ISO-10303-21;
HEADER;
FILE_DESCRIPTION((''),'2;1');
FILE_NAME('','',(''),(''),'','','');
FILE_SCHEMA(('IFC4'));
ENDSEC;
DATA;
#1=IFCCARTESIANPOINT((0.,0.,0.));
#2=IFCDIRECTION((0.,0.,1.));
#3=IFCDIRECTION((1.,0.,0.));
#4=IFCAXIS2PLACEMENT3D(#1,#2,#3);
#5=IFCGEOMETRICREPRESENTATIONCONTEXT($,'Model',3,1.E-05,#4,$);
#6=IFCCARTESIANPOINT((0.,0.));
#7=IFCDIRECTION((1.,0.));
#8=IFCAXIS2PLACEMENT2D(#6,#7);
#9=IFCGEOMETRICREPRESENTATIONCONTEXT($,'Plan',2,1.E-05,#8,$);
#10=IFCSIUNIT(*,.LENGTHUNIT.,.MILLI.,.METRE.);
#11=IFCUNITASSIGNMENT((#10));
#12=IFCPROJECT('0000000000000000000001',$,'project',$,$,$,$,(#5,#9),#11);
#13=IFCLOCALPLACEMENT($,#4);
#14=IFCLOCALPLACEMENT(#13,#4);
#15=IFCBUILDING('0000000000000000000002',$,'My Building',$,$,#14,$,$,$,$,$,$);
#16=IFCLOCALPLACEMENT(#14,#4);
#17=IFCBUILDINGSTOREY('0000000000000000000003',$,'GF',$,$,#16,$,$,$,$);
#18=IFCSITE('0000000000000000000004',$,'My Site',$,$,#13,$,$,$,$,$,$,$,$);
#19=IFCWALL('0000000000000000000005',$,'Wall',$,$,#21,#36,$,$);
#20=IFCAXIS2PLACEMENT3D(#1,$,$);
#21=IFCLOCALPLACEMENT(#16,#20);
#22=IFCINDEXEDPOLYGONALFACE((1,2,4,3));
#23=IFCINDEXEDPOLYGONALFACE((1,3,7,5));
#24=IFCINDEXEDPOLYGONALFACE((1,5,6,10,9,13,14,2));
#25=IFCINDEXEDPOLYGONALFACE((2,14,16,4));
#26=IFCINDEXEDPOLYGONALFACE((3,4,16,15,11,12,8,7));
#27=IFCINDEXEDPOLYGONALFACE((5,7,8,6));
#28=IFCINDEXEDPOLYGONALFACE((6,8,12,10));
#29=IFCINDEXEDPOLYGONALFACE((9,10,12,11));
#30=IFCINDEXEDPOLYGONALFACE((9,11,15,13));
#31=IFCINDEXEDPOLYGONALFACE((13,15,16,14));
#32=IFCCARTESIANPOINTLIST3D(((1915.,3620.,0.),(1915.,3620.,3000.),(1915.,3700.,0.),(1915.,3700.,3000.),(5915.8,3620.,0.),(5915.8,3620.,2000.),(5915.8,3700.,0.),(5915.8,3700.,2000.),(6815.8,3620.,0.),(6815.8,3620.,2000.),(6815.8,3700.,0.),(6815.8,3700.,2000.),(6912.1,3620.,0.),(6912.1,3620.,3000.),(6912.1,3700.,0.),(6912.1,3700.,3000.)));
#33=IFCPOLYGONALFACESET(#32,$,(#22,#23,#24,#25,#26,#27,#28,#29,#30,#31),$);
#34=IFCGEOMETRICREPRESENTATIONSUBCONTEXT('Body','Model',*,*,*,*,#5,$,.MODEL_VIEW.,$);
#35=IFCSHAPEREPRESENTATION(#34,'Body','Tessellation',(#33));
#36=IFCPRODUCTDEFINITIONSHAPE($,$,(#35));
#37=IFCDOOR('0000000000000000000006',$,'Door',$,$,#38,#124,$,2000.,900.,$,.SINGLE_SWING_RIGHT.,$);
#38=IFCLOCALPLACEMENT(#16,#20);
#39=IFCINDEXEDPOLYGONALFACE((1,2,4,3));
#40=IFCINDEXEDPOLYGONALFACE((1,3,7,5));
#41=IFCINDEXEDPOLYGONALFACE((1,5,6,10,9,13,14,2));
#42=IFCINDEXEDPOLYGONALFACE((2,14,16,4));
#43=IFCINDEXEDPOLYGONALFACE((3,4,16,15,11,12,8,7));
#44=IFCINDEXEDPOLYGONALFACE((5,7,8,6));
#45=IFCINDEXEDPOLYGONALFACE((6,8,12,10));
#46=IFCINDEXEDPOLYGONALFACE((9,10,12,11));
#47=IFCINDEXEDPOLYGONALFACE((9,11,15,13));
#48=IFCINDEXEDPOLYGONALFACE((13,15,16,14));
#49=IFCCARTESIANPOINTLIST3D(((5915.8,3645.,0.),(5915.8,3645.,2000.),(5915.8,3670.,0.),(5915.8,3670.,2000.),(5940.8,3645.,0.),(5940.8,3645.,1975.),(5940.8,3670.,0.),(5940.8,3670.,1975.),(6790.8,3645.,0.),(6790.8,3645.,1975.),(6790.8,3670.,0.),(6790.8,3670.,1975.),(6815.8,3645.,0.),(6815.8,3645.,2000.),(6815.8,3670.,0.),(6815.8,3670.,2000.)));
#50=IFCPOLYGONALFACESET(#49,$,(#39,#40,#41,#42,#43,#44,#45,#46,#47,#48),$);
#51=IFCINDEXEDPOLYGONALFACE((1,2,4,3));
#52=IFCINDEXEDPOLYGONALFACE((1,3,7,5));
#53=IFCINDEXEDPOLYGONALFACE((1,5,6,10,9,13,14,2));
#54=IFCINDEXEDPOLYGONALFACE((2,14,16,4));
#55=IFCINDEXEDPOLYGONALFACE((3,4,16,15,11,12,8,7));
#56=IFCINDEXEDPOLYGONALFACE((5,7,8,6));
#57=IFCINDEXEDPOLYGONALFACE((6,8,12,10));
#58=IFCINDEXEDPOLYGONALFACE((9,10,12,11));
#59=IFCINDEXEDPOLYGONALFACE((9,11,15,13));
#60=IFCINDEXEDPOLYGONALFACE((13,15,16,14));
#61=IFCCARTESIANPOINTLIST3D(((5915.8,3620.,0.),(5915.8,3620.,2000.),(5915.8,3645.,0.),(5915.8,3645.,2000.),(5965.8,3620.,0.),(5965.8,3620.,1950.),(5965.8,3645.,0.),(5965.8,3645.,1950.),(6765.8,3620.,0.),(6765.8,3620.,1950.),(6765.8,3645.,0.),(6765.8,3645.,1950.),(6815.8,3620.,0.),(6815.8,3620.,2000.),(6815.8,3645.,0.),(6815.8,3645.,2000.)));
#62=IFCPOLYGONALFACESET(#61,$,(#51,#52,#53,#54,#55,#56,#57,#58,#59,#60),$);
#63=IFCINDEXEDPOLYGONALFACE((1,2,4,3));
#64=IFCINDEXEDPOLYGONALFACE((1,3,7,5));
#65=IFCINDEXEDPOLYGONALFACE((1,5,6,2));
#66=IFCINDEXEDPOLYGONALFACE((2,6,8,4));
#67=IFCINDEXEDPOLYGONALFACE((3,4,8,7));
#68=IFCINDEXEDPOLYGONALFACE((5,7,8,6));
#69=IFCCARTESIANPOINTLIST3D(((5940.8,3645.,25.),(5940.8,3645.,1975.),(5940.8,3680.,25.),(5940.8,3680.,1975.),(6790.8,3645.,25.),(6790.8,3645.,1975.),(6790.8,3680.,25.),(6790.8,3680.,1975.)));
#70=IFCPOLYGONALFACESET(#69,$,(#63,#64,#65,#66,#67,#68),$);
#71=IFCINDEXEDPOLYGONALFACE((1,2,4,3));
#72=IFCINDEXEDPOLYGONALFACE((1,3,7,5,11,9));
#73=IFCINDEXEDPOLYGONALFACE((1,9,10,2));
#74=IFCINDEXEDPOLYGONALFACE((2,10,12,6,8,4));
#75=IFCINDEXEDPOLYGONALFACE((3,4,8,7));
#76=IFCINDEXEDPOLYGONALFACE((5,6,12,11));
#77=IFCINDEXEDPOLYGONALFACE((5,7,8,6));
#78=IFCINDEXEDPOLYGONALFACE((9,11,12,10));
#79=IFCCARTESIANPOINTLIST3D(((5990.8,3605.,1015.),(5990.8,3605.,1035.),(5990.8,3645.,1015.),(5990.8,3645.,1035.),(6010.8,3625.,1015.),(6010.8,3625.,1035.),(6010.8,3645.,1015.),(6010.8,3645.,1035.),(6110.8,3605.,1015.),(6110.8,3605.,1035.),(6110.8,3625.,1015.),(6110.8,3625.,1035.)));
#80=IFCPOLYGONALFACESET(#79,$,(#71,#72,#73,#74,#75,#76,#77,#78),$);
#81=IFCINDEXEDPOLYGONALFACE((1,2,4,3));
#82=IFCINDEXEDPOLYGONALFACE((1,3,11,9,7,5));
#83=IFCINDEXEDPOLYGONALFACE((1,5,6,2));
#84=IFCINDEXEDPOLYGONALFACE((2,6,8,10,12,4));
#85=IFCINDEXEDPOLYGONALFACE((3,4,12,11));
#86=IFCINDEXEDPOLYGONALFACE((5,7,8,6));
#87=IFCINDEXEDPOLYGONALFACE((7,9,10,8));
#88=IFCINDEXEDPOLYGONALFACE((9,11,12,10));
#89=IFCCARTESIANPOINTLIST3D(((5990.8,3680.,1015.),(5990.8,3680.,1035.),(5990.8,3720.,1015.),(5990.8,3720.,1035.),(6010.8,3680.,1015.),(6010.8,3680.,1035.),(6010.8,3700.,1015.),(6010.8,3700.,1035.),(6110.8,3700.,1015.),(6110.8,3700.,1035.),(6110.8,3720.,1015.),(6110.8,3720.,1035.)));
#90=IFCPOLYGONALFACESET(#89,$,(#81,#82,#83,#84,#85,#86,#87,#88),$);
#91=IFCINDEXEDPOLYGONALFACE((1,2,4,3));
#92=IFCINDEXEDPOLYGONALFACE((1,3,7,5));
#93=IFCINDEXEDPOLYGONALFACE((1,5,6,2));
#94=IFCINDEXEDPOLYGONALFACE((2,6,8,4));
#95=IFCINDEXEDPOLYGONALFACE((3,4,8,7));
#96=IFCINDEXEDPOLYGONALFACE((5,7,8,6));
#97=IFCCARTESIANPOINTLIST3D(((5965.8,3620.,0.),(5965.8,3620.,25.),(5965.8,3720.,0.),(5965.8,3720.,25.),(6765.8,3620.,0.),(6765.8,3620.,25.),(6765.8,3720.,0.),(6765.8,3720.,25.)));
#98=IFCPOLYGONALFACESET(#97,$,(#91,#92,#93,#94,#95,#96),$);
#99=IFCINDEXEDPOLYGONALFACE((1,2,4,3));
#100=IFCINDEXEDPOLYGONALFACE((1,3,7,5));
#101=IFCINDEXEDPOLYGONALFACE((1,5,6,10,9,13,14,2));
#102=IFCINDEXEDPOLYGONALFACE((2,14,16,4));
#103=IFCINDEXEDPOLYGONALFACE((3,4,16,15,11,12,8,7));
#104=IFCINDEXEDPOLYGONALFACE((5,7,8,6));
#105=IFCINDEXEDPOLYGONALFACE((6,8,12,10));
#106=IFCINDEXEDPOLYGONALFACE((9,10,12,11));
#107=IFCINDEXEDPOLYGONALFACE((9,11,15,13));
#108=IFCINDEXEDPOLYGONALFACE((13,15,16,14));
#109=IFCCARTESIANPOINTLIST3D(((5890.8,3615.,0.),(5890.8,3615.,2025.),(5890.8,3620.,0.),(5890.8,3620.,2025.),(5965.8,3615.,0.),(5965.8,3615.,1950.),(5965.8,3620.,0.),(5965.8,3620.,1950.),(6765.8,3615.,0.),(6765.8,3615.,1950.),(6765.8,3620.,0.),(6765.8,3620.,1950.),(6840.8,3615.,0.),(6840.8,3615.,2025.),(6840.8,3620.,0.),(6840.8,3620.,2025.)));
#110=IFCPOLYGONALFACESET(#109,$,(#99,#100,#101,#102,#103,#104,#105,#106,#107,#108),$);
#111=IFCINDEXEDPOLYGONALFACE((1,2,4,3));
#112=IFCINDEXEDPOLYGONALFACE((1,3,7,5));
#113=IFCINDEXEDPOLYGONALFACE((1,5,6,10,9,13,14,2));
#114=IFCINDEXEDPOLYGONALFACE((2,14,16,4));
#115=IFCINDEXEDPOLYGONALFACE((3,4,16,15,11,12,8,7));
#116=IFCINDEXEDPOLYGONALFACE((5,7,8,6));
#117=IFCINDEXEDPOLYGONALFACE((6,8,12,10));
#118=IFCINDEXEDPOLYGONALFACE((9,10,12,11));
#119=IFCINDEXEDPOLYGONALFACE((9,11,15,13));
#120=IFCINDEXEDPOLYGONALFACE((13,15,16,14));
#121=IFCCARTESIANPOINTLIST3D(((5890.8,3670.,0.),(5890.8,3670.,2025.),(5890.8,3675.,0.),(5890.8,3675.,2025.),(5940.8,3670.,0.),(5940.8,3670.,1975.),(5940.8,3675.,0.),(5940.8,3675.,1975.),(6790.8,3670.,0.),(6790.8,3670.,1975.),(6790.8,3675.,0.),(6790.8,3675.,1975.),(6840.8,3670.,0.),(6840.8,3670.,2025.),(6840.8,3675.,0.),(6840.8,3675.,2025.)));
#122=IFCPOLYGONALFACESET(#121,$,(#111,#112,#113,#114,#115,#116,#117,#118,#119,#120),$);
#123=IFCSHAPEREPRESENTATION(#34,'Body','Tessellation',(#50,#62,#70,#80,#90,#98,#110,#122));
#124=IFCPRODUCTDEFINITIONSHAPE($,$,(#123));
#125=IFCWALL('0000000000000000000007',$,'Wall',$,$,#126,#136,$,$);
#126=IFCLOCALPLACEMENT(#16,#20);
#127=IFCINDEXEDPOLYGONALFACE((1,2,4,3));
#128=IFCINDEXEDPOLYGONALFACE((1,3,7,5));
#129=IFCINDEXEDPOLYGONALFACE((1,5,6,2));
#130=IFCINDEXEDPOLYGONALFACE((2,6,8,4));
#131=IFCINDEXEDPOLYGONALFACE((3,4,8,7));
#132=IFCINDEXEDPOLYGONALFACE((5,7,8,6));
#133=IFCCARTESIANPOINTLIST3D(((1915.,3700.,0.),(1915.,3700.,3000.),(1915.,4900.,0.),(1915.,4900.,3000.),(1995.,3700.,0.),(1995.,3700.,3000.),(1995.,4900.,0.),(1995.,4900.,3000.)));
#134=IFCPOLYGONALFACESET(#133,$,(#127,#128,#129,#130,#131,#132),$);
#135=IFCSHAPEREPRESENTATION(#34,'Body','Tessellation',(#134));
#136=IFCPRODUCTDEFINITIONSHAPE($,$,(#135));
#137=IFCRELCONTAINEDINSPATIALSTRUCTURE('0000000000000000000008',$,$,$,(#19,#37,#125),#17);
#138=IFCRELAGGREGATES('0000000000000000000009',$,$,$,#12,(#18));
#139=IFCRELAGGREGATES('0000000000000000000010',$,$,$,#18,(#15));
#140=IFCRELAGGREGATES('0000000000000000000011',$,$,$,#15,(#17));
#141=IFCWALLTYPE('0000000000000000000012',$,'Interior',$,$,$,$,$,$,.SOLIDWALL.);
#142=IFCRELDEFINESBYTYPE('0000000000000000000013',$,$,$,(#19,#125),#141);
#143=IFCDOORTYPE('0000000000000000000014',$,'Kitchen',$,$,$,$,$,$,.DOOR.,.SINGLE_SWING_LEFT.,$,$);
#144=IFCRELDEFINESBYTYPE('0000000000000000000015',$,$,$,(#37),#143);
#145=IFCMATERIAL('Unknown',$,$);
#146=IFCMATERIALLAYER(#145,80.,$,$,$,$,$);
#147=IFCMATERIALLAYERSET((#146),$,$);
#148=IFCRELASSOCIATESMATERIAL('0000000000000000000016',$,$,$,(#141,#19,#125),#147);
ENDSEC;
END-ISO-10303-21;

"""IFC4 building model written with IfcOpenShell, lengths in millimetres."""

from ifc_helpers import new_model, entity, si_unit, frame, origin_with_axes, origin_2d_with_axis, place, context, subcontext, project, spatial, line, indexed_curve, outline, extrude, shape, source, transform, mapped, material, layer, layer_set, layer_usage, type_object, type_shapes, element, fill, save


model = new_model("IFC4")

# Units and contexts
model_context = context("Model", 3, precision=1e-05, world=origin_with_axes())
plan_context = context("Plan", 2, precision=1e-05, world=origin_2d_with_axis())
body_context_1 = subcontext(model_context, "Body", "Model", "MODEL_VIEW")
body_context_2 = subcontext(plan_context, "Body", "Plan", "PLAN_VIEW")
ifc_project = project(units=[si_unit("LENGTHUNIT", "METRE", prefix="MILLI")], contexts=[model_context, plan_context])

# Site, building, storey
site_placement = place(None, origin_with_axes())
site = spatial("IfcSite", under=ifc_project, at=site_placement, Name="My Site")
building_placement = place(site_placement, origin_with_axes())
building = spatial("IfcBuilding", under=site, at=building_placement, Name="My Building")
storey_placement = place(building_placement, origin_with_axes())
storey = spatial("IfcBuildingStorey", under=building, at=storey_placement, Name="GF")

# Shared definitions
ifc_material = material(Name="Unknown")

# Shared definitions
ifc_layer_1 = layer(ifc_material, 80.0)
ifc_layer_set_1 = layer_set([ifc_layer_1])
wall_type_1 = type_object("IfcWallType", Name="Interior", PredefinedType="SOLIDWALL", material=ifc_layer_set_1)

# Wall, opening, door
ifc_layer_usage_1 = layer_usage(ifc_layer_set_1, "AXIS2", "POSITIVE", 0.0)
wall_1_placement = place(storey_placement, frame((1915.0, 3620.0, 0.0), z_axis=(0.0, 0.0, 1.0), x_axis=(1.0, 0.0, 0.0)))
wall_1 = element("IfcWall", 1, at=wall_1_placement, inside=storey, type_object=wall_type_1, material=ifc_layer_usage_1, Name="Wall", context=body_context_1, shape_type="SweptSolid", body=[
    extrude(outline(indexed_curve([(0.0, 0.0), (0.0, 80.0), (4997.2, 80.0), (4997.2, 0.0)], segments=[line(1, 2, 3, 4, 1)])), origin_with_axes(), (0.0, 0.0, 1.0), 3000.0),
])
shared_shape_1 = source(origin_with_axes(), body_context_1, "Body", "SweptSolid", [
    extrude(outline(indexed_curve([(0.0, 0.0), (900.0, 0.0), (900.0, 2000.0), (0.0, 2000.0)], segments=[line(1, 2, 3, 4, 1)])), frame((0.0, -600.0, 0.0), z_axis=(0.0, -1.0, 0.0), x_axis=(1.0, 0.0, 0.0)), (0.0, 0.0, -1.0), 1200.0),
])
opening_1_placement = place(wall_1_placement, frame((4000.8, 0.0, 0.0), z_axis=(0.0, 0.0, 1.0), x_axis=(1.0, 0.0, 0.0)))
opening_1 = element("IfcOpeningElement", 2, at=opening_1_placement, cuts=wall_1, PredefinedType="OPENING", context=body_context_1, shape_type="MappedRepresentation", body=[
    mapped(shared_shape_1, transform((0.0, 0.0, 0.0), x_axis=(1.0, 0.0, 0.0), y_axis=(0.0, 1.0, 0.0), z_axis=(0.0, 0.0, 1.0), scale=1.0)),
])
door_type_1 = type_object("IfcDoorType", Name="Kitchen", OperationType="SINGLE_SWING_LEFT", PredefinedType="DOOR")
shared_shape_2 = source(origin_with_axes(), body_context_1, "Body", "SweptSolid", [
    extrude(outline(indexed_curve([(0.0, 0.0), (0.0, 2000.0), (900.0, 2000.0), (900.0, 0.0), (875.0, 0.0), (875.0, 1975.0), (25.0, 1975.0), (25.0, 0.0)], segments=[line(1, 2, 3, 4, 5, 6, 7, 8, 1)])), frame((0.0, 25.0, 0.0), z_axis=(0.0, -1.0, 0.0), x_axis=(1.0, 0.0, 0.0)), (0.0, 0.0, -1.0), 25.0),
    extrude(outline(indexed_curve([(0.0, 0.0), (0.0, 2000.0), (900.0, 2000.0), (900.0, 0.0), (850.0, 0.0), (850.0, 1950.0), (50.0, 1950.0), (50.0, 0.0)], segments=[line(1, 2, 3, 4, 5, 6, 7, 8, 1)])), frame((0.0, 0.0, 0.0), z_axis=(0.0, -1.0, 0.0), x_axis=(1.0, 0.0, 0.0)), (0.0, 0.0, -1.0), 25.0),
    extrude(outline(indexed_curve([(0.0, 0.0), (850.0, 0.0), (850.0, 35.0), (0.0, 35.0)], segments=[line(1, 2, 3, 4, 1)])), frame((25.0, 25.0, 25.0), z_axis=(0.0, 0.0, 1.0), x_axis=(1.0, 0.0, 0.0)), (0.0, 0.0, 1.0), 1950.0),
    extrude(outline(indexed_curve([(0.0, 0.0), (0.0, -40.0), (120.0, -40.0), (120.0, -20.0), (20.0, -20.0), (20.0, 0.0)], segments=[line(1, 2, 3, 4, 5, 6, 1)])), frame((75.0, 25.0, 1015.0), z_axis=(0.0, 0.0, 1.0), x_axis=(1.0, 0.0, 0.0)), (0.0, 0.0, 1.0), 20.0),
    extrude(outline(indexed_curve([(0.0, 0.0), (0.0, 40.0), (120.0, 40.0), (120.0, 20.0), (20.0, 20.0), (20.0, 0.0)], segments=[line(1, 2, 3, 4, 5, 6, 1)])), frame((75.0, 60.0, 1015.0), z_axis=(0.0, 0.0, 1.0), x_axis=(1.0, 0.0, 0.0)), (0.0, 0.0, 1.0), 20.0),
    extrude(outline(indexed_curve([(0.0, 0.0), (800.0, 0.0), (800.0, 100.0), (0.0, 100.0)], segments=[line(1, 2, 3, 4, 1)])), frame((50.0, 0.0, 0.0), z_axis=(0.0, 0.0, 1.0), x_axis=(1.0, 0.0, 0.0)), (0.0, 0.0, 1.0), 25.0),
    extrude(outline(indexed_curve([(0.0, 0.0), (0.0, 2025.0), (950.0, 2025.0), (950.0, 0.0), (875.0, 0.0), (875.0, 1950.0), (75.0, 1950.0), (75.0, 0.0)], segments=[line(1, 2, 3, 4, 5, 6, 7, 8, 1)])), frame((-25.0, -5.0, 0.0), z_axis=(0.0, -1.0, 0.0), x_axis=(1.0, 0.0, 0.0)), (0.0, 0.0, -1.0), 5.0),
    extrude(outline(indexed_curve([(0.0, 0.0), (0.0, 2025.0), (950.0, 2025.0), (950.0, 0.0), (900.0, 0.0), (900.0, 1975.0), (50.0, 1975.0), (50.0, 0.0)], segments=[line(1, 2, 3, 4, 5, 6, 7, 8, 1)])), frame((-25.0, 50.0, 0.0), z_axis=(0.0, -1.0, 0.0), x_axis=(1.0, 0.0, 0.0)), (0.0, 0.0, -1.0), 5.0),
])
shared_shape_3 = source(origin_with_axes(), body_context_2, "Body", "Curve2D", [
    entity("IfcIndexedPolyCurve", entity("IfcCartesianPointList2D", [[0.0, 0.0], [0.0, 50.0], [25.0, 50.0], [25.0, 25.0], [50.0, 25.0], [50.0, 0.0]]), [entity("IfcLineIndex", [1, 2, 3, 4, 5, 6, 1])]),
    entity("IfcIndexedPolyCurve", entity("IfcCartesianPointList2D", [[900.0, 0.0], [900.0, 50.0], [875.0, 50.0], [875.0, 25.0], [850.0, 25.0], [850.0, 0.0]]), [entity("IfcLineIndex", [1, 2, 3, 4, 5, 6, 1])]),
    entity("IfcTrimmedCurve", entity("IfcEllipse", entity("IfcAxis2Placement2D", entity("IfcCartesianPoint", [840.0, 50.0]), entity("IfcDirection", [1.0, 0.0])), 815.0, 850.0), [entity("IfcCartesianPoint", [840.0, 900.0])], [entity("IfcCartesianPoint", [25.0, 50.0])], True, "CARTESIAN"),
    entity("IfcIndexedPolyCurve", entity("IfcCartesianPointList2D", [[875.0, 50.0], [840.0, 50.0], [840.0, 900.0], [875.0, 900.0]]), [entity("IfcLineIndex", [1, 2, 3, 4, 1])]),
])
type_shapes(door_type_1, [shared_shape_2, shared_shape_3])
door_1_placement = place(opening_1_placement, frame((0.0, 0.0, 0.0), z_axis=(0.0, 0.0, 1.0), x_axis=(1.0, 0.0, 0.0)))
door_1 = element("IfcDoor", 3, at=door_1_placement, inside=storey, type_object=door_type_1, Name="Door", OperationType="SINGLE_SWING_RIGHT", OverallHeight=2000.0, OverallWidth=900.0, shapes=[
    shape(body_context_1, "Body", "MappedRepresentation", [mapped(shared_shape_2, transform((0.0, 0.0, 0.0), x_axis=(1.0, 0.0, 0.0), y_axis=(0.0, 1.0, 0.0), z_axis=(0.0, 0.0, 1.0), scale=1.0))]),
    shape(body_context_2, "Body", "MappedRepresentation", [mapped(shared_shape_3, transform((0.0, 0.0, 0.0), x_axis=(1.0, 0.0, 0.0), y_axis=(0.0, 1.0, 0.0), z_axis=(0.0, 0.0, 1.0), scale=1.0))]),
])
fill(opening_1, door_1)

# Wall
ifc_layer_usage_2 = layer_usage(ifc_layer_set_1, "AXIS2", "POSITIVE", 0.0)
wall_2_placement = place(storey_placement, frame((1915.0, 4900.0, 0.0), z_axis=(0.0, 0.0, 1.0), x_axis=(0.0, -1.0, 0.0)))
element("IfcWall", 4, at=wall_2_placement, inside=storey, type_object=wall_type_1, material=ifc_layer_usage_2, Name="Wall", context=body_context_1, shape_type="SweptSolid", body=[
    extrude(outline(indexed_curve([(0.0, 0.0), (0.0, 80.0), (1200.0, 80.0), (1200.0, 0.0)], segments=[line(1, 2, 3, 4, 1)])), origin_with_axes(), (0.0, 0.0, 1.0), 3000.0),
])

save(model, "model.ifc")
